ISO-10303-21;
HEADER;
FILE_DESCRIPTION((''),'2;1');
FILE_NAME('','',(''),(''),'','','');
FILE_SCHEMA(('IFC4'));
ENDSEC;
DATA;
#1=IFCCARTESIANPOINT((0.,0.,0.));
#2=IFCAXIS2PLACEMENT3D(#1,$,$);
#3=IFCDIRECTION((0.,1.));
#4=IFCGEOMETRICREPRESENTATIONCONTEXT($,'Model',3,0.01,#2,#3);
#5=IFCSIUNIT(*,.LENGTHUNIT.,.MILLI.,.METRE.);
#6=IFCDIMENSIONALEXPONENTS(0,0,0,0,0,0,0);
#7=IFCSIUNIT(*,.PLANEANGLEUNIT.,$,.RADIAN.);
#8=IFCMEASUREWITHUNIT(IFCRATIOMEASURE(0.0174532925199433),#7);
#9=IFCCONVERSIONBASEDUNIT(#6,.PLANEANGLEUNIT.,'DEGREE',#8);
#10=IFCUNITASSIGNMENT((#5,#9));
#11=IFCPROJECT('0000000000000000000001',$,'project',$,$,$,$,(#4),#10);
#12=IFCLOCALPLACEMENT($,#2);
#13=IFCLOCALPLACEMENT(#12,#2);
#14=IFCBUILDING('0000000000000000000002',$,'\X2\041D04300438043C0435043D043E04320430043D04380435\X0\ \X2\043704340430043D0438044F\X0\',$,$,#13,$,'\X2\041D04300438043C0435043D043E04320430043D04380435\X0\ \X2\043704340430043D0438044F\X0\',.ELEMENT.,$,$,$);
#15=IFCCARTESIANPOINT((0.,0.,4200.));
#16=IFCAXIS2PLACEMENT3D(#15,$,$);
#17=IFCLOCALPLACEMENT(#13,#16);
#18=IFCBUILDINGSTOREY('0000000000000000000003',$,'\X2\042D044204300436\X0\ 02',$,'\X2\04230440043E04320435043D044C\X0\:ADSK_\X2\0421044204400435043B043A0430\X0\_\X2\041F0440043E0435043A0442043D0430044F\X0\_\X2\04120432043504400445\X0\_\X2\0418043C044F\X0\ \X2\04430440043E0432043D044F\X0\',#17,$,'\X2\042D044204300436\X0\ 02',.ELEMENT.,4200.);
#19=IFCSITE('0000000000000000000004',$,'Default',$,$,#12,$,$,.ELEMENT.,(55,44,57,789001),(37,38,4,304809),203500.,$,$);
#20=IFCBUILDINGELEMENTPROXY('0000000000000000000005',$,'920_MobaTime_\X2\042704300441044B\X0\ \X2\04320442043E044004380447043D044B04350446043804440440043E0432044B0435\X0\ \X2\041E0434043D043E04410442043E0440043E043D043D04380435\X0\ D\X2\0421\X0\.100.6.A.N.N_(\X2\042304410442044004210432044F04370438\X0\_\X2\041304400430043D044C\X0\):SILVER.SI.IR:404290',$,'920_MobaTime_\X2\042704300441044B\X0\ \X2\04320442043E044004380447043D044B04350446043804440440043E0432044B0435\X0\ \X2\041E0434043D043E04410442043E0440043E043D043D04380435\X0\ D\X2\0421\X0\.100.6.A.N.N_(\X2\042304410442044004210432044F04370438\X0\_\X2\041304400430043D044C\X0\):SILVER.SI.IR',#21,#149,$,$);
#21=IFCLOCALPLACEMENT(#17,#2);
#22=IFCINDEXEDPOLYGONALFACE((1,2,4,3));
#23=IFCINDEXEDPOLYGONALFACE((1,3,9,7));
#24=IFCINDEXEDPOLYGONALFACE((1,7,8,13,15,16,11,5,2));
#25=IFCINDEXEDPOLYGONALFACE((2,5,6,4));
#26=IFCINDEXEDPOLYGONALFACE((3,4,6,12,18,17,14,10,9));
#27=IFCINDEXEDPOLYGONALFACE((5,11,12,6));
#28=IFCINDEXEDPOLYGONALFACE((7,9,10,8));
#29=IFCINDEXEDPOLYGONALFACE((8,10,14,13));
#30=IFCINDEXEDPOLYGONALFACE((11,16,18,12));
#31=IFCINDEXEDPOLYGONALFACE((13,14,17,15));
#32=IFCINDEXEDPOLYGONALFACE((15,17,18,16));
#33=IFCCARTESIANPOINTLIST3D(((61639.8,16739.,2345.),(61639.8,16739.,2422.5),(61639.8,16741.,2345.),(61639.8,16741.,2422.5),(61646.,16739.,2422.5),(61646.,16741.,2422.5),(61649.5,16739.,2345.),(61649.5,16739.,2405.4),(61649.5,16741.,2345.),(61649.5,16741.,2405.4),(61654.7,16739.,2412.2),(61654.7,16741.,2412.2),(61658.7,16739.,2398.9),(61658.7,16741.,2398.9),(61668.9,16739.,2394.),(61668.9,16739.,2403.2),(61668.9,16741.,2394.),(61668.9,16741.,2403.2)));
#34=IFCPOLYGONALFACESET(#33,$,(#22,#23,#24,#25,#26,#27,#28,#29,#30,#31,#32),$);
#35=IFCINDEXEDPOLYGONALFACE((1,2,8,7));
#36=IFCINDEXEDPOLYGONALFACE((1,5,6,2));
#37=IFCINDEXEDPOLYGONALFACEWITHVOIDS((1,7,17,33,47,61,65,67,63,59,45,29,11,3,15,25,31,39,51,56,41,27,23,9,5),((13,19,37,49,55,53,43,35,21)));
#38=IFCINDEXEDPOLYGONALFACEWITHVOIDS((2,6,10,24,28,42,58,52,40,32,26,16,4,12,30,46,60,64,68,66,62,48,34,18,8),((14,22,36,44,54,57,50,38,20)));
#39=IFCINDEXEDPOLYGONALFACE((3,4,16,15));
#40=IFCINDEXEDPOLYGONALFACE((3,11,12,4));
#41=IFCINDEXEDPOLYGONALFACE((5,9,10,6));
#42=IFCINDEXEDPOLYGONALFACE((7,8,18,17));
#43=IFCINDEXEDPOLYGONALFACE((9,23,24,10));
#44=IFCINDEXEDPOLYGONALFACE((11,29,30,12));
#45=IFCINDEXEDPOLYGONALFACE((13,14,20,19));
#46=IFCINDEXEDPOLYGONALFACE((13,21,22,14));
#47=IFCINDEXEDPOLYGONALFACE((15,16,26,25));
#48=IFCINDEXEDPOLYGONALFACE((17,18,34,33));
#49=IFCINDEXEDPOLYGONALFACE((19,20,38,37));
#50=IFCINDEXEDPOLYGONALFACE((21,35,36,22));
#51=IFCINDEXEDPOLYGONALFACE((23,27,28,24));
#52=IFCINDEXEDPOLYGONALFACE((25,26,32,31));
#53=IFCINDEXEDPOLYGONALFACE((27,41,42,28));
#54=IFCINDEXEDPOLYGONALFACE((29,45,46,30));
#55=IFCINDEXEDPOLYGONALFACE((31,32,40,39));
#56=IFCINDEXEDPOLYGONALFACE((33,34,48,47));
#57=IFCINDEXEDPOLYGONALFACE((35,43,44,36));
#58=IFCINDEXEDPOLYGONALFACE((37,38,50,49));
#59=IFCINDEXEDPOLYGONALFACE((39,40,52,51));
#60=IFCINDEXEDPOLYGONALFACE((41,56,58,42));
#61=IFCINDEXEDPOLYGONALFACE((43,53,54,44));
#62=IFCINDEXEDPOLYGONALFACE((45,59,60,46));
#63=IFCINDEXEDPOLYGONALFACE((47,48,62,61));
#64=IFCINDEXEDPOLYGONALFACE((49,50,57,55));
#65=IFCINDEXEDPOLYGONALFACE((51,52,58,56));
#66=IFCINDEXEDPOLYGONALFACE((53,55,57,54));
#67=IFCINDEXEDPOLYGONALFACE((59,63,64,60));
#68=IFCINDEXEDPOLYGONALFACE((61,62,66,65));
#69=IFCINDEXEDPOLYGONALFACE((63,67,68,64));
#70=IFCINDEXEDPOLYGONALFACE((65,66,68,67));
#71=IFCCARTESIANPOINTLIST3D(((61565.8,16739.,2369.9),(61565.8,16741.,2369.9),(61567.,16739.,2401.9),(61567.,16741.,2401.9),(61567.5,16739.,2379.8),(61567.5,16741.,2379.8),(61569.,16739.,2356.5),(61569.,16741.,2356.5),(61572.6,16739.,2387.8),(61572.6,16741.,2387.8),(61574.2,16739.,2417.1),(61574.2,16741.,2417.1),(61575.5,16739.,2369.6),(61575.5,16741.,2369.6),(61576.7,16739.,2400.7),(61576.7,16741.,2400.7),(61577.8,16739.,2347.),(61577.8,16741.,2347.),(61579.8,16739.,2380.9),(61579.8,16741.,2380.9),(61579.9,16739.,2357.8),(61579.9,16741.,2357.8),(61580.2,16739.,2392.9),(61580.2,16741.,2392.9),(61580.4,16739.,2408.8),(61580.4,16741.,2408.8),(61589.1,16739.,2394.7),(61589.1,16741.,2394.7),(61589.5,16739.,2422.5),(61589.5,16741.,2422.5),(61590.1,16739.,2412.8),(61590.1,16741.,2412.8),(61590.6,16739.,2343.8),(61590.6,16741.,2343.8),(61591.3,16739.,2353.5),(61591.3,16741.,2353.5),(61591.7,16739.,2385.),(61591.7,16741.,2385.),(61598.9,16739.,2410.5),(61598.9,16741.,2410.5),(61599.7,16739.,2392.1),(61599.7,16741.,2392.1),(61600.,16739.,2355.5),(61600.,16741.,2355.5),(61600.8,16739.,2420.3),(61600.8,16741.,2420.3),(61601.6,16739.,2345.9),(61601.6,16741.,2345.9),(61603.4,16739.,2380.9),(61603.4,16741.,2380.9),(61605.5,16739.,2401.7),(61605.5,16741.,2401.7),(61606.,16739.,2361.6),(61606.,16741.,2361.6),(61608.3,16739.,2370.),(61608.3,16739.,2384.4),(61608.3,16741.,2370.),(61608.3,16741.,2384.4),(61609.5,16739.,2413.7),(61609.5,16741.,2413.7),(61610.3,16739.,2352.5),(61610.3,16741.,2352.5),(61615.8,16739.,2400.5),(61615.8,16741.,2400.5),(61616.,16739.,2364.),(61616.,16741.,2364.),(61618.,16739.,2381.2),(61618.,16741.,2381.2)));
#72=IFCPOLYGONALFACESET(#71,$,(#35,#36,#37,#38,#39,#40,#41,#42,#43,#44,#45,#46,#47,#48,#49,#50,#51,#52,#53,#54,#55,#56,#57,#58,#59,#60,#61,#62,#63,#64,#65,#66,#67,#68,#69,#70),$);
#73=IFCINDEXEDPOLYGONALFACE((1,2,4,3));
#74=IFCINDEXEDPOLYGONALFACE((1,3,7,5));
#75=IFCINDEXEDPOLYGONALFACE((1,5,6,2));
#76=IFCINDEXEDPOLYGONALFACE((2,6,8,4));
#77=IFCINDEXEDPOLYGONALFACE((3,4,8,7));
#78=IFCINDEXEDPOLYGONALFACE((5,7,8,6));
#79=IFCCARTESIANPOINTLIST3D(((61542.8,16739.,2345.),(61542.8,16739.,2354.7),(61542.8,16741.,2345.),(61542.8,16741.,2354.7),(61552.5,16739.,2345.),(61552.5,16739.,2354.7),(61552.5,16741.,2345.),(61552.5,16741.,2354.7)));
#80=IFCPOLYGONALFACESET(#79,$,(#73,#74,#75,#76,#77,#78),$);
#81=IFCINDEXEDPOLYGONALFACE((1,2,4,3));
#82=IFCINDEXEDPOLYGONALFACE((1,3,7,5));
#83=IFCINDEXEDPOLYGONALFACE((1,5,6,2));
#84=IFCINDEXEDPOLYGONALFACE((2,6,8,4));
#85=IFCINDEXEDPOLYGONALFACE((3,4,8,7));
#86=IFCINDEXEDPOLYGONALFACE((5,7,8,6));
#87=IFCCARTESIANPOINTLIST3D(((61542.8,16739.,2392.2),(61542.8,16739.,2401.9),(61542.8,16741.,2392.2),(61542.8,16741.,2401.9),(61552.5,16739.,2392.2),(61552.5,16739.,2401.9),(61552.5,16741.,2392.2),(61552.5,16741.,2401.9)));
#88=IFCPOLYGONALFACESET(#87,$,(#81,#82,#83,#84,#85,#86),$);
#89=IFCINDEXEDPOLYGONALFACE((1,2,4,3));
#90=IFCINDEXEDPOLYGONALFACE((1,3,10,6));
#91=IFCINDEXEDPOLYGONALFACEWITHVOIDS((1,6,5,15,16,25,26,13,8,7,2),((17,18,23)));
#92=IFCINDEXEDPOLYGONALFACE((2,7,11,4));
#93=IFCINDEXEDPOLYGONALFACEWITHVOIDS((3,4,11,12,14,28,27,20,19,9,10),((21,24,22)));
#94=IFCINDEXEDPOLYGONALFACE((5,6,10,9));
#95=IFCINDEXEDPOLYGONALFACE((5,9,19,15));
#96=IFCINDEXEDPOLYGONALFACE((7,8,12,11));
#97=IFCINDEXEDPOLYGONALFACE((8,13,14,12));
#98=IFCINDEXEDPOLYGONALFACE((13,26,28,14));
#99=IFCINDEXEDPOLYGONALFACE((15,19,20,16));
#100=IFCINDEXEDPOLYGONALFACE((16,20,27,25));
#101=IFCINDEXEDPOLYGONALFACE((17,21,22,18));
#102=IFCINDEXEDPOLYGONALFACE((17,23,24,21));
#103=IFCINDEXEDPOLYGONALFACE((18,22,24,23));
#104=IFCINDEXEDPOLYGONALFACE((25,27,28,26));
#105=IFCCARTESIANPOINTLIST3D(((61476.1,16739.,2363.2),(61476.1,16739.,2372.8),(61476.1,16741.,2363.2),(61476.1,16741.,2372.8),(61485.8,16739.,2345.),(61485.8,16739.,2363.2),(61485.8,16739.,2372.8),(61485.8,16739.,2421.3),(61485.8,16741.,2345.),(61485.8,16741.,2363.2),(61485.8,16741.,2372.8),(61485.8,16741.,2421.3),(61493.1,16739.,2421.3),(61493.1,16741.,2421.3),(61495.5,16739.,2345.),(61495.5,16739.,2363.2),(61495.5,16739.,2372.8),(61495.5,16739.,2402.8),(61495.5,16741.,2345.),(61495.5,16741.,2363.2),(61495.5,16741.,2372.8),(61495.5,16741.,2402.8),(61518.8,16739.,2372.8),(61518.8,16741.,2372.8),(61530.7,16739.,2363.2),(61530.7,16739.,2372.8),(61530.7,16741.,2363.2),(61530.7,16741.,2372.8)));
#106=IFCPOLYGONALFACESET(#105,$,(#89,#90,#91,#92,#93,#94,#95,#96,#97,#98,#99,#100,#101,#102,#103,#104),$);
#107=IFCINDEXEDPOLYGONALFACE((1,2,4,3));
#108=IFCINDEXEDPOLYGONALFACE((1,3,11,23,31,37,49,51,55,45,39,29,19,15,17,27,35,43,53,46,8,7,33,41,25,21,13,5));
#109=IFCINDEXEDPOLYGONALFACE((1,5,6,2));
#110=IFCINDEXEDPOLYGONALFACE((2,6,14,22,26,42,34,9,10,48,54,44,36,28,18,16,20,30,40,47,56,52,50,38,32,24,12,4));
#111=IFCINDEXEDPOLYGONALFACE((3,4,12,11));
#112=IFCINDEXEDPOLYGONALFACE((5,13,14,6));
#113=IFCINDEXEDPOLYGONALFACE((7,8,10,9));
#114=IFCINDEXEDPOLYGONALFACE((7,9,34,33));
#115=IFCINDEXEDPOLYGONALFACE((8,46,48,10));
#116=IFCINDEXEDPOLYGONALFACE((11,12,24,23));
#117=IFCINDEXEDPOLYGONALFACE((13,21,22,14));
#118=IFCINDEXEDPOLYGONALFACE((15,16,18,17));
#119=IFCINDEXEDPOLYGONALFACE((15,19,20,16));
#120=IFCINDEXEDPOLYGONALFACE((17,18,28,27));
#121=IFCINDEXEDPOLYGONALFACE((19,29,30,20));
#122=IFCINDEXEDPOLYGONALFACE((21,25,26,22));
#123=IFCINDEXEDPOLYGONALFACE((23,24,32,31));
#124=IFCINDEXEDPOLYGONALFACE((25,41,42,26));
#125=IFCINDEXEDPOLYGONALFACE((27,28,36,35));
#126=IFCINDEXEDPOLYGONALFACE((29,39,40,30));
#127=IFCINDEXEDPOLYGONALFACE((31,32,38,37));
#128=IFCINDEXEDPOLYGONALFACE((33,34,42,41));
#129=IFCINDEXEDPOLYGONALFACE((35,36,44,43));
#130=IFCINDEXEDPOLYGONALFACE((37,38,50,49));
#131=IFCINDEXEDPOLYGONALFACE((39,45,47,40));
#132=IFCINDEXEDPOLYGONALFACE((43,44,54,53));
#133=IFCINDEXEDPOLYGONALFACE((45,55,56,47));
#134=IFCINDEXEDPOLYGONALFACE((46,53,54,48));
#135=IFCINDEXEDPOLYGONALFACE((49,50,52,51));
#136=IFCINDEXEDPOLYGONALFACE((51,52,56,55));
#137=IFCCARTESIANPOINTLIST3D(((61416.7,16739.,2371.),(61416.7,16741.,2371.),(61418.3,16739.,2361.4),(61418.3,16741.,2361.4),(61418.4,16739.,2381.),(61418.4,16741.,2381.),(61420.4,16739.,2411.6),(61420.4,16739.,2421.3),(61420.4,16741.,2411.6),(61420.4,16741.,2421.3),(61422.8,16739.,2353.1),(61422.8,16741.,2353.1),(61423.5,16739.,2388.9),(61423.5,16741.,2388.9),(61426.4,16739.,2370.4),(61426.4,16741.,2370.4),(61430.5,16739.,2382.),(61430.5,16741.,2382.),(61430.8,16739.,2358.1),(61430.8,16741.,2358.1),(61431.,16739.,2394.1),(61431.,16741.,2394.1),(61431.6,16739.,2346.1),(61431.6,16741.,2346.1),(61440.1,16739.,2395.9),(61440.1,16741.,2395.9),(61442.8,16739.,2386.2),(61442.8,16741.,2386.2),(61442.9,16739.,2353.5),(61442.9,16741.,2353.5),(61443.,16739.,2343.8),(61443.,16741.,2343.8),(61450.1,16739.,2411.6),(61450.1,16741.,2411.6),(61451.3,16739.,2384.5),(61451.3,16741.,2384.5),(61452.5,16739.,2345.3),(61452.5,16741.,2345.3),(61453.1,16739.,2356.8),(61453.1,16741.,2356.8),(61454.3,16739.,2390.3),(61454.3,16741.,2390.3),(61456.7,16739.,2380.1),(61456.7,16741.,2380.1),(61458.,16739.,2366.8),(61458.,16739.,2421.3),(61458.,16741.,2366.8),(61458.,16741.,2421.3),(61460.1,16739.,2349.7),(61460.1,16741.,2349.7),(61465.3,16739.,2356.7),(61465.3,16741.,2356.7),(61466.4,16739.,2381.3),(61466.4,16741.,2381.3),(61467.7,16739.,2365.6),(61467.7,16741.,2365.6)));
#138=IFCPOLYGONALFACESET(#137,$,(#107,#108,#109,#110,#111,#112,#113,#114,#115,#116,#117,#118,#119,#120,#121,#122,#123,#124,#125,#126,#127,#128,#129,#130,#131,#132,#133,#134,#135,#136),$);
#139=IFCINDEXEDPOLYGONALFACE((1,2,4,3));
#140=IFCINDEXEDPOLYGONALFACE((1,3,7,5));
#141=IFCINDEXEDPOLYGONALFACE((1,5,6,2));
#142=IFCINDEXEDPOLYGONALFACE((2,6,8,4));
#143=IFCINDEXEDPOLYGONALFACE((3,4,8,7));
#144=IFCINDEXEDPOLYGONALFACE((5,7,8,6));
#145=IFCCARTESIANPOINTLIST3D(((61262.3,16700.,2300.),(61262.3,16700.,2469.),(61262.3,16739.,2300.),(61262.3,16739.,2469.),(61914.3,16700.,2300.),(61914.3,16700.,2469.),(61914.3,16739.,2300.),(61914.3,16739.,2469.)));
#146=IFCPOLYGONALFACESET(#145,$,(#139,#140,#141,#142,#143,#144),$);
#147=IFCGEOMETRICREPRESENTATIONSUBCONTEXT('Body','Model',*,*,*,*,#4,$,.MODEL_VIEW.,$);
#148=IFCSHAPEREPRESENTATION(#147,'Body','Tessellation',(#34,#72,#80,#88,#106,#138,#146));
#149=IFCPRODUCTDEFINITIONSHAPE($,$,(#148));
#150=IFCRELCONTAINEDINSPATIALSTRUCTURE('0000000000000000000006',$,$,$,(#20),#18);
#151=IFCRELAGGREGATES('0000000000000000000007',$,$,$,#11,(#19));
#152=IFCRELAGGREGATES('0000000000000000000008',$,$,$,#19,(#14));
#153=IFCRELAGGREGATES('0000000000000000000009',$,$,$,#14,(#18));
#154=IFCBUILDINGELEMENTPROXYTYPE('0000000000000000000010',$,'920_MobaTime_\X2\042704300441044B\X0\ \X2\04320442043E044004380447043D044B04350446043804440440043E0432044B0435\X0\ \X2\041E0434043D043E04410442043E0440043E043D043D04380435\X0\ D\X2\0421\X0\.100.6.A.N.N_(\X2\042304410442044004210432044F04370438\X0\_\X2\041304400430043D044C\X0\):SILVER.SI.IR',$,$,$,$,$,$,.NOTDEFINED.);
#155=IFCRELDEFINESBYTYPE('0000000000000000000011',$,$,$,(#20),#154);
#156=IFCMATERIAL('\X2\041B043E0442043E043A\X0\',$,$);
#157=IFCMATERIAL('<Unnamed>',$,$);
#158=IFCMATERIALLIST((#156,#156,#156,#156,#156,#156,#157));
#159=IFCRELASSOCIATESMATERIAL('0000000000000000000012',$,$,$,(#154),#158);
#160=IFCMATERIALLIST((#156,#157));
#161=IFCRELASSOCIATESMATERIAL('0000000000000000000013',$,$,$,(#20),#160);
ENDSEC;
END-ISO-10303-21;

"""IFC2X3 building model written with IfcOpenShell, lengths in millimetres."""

from ifc_helpers import new_model, entity, si_unit, converted_unit, direction, frame, origin, origin_2d_with_axis, place, context, subcontext, project, spatial, polyline, rectangle, outline, extrude, source, transform, mapped, material, material_list, type_object, type_shapes, element, save


model = new_model("IFC2X3")

# Units and contexts
model_context = context("Model", 3, precision=0.01, world=origin(), true_north=direction((0.0, 1.0)))
body_context = subcontext(model_context, "Body", "Model", "MODEL_VIEW")
ifc_project = project(units=[si_unit("LENGTHUNIT", "METRE", prefix="MILLI"), converted_unit("PLANEANGLEUNIT", "DEGREE", entity("IfcRatioMeasure", 0.0174532925199433), si_unit("PLANEANGLEUNIT", "RADIAN"), dimensions=[0, 0, 0, 0, 0, 0, 0])], contexts=[model_context])

# Site, building, storey
site_placement = place(None, frame((0.0, 0.0, 0.0)))
site = spatial("IfcSite", under=ifc_project, at=site_placement, Name="Default", CompositionType="ELEMENT", RefLatitude=(55, 44, 57, 789001), RefLongitude=(37, 38, 4, 304809), RefElevation=203500.0)
building_placement = place(site_placement, origin())
building = spatial("IfcBuilding", under=site, at=building_placement, Name="Наименование здания", LongName="Наименование здания", CompositionType="ELEMENT")
storey_placement = place(building_placement, frame((0.0, 0.0, 4200.0)))
storey = spatial("IfcBuildingStorey", under=building, at=storey_placement, Name="Этаж 02", ObjectType="Уровень:ADSK_Стрелка_Проектная_Вверх_Имя уровня", LongName="Этаж 02", CompositionType="ELEMENT", Elevation=4200.0)

# Building element proxy
ifc_material_1 = material(Name="Лоток")
ifc_material_2 = material(Name="<Unnamed>")
ifc_material_list_1 = material_list([ifc_material_1, ifc_material_1, ifc_material_1, ifc_material_1, ifc_material_1, ifc_material_1, ifc_material_2])
building_element_proxy_type_1 = type_object("IfcBuildingElementProxyType", Name="920_MobaTime_Часы вторичныецифровые Односторонние DС.100.6.A.N.N_(УстрСвязи_Грань):SILVER.SI.IR", PredefinedType="NOTDEFINED", material=ifc_material_list_1)
shared_shape_1 = source(origin(), body_context, "Body", "SweptSolid", [
    extrude(outline(polyline([(-49.3, -13.1), (28.2, -13.1), (28.2, -6.8), (17.9, 1.8), (8.9, 16.0), (-0.3, 16.0), (4.6, 5.8), (11.1, -3.4), (-49.3, -3.4), (-49.3, -13.1)])), frame((-64.6, 9.8, 39.0), z_axis=(0.0, 0.0, 1.0), x_axis=(0.0, 1.0, 0.0)), (0.0, 0.0, 1.0), 2.0),
    extrude(outline(polyline([(2.2, -27.6), (19.0, -27.6), (30.5, -16.1), (33.3, -4.9), (31.0, 5.8), (21.8, 17.2), (5.2, 27.3), (-11.1, 33.0), (-24.0, 32.7), (-33.6, 27.6), (-40.3, 18.6), (-42.8, 5.7), (-38.0, -6.3), (-27.2, -15.0), (-17.5, -17.7), (-8.2, -16.4), (-0.3, -11.9), (5.1, -4.5), (7.3, 6.2), (4.0, 17.2), (18.5, 7.3), (23.6, -2.4), (22.0, -11.4), (14.2, -18.4), (5.3, -18.3), (2.2, -27.6)]), holes=[polyline([(-9.0, 23.3), (-1.3, 14.4), (-2.6, 2.0), (-11.4, -7.0), (-23.4, -6.1), (-32.2, 2.9), (-31.2, 15.1), (-25.6, 22.1), (-17.5, 24.9), (-9.0, 23.3)])]), frame((-2.7, 3.6, 39.0), z_axis=(0.0, 0.0, 1.0), x_axis=(-0.427649, 0.903945, 0.0)), (0.0, 0.0, 1.0), 2.0),
    extrude(rectangle(XDim=9.7, YDim=9.7, at=origin_2d_with_axis()), frame((40.6, -34.7, 39.0)), (0.0, 0.0, 1.0), 2.0),
    extrude(rectangle(XDim=9.7, YDim=9.7, at=origin_2d_with_axis()), frame((40.6, 12.6, 39.0)), (0.0, 0.0, 1.0), 2.0),
    extrude(outline(polyline([(-0.9, -28.1), (8.8, -28.1), (8.8, -9.9), (18.5, -9.9), (18.5, -0.2), (8.8, -0.2), (8.8, 48.3), (1.5, 48.3), (-36.0, -0.2), (-36.0, -9.9), (-0.9, -9.9), (-0.9, -28.1)]), holes=[polyline([(-0.9, -0.2), (-24.1, -0.2), (-0.9, 29.7), (-0.9, -0.2)])]), frame((93.6, -11.4, 39.0)), (0.0, 0.0, 1.0), 2.0),
    extrude(outline(polyline([(3.3, -28.3), (12.5, -28.3), (20.5, -25.0), (26.8, -18.8), (30.7, -10.0), (31.4, 1.6), (26.9, 11.8), (20.1, 18.4), (11.1, 22.3), (1.0, 23.3), (-7.9, 20.4), (-14.9, 14.5), (-18.9, 6.2), (-17.1, -9.0), (-36.7, 0.5), (-29.1, 29.3), (-38.5, 31.7), (-48.1, -4.6), (-11.6, -23.0), (-8.0, -14.0), (-10.8, -7.6), (-10.2, 1.1), (-3.0, 11.8), (9.2, 12.8), (20.0, 5.4), (21.3, -7.5), (15.5, -16.4), (4.6, -18.6), (3.3, -28.3)])), frame((147.1, -8.5, 39.0), z_axis=(0.0, 0.0, 1.0), x_axis=(0.256974, -0.966418, 0.0)), (0.0, 0.0, 1.0), 2.0),
    extrude(rectangle(XDim=652.0, YDim=169.0, at=origin_2d_with_axis()), frame((0.0, 0.0, 0.0), z_axis=(0.0, 0.0, 1.0), x_axis=(-1.0, 0.0, 0.0)), (0.0, 0.0, 1.0), 39.0),
])
type_shapes(building_element_proxy_type_1, [shared_shape_1])
ifc_material_list_2 = material_list([ifc_material_1, ifc_material_2])
proxy_1_placement = place(storey_placement, frame((61588.3, 16700.0, 2384.5), z_axis=(0.0, 1.0, 0.0), x_axis=(-1.0, 0.0, 0.0)))
element("IfcBuildingElementProxy", 1, at=proxy_1_placement, inside=storey, type_object=building_element_proxy_type_1, material=ifc_material_list_2, Name="920_MobaTime_Часы вторичныецифровые Односторонние DС.100.6.A.N.N_(УстрСвязи_Грань):SILVER.SI.IR:404290", ObjectType="920_MobaTime_Часы вторичныецифровые Односторонние DС.100.6.A.N.N_(УстрСвязи_Грань):SILVER.SI.IR", context=body_context, shape_type="MappedRepresentation", body=[
    mapped(shared_shape_1, transform((0.0, 0.0, 0.0), scale=1.0)),
])

save(model, "model.ifc")
